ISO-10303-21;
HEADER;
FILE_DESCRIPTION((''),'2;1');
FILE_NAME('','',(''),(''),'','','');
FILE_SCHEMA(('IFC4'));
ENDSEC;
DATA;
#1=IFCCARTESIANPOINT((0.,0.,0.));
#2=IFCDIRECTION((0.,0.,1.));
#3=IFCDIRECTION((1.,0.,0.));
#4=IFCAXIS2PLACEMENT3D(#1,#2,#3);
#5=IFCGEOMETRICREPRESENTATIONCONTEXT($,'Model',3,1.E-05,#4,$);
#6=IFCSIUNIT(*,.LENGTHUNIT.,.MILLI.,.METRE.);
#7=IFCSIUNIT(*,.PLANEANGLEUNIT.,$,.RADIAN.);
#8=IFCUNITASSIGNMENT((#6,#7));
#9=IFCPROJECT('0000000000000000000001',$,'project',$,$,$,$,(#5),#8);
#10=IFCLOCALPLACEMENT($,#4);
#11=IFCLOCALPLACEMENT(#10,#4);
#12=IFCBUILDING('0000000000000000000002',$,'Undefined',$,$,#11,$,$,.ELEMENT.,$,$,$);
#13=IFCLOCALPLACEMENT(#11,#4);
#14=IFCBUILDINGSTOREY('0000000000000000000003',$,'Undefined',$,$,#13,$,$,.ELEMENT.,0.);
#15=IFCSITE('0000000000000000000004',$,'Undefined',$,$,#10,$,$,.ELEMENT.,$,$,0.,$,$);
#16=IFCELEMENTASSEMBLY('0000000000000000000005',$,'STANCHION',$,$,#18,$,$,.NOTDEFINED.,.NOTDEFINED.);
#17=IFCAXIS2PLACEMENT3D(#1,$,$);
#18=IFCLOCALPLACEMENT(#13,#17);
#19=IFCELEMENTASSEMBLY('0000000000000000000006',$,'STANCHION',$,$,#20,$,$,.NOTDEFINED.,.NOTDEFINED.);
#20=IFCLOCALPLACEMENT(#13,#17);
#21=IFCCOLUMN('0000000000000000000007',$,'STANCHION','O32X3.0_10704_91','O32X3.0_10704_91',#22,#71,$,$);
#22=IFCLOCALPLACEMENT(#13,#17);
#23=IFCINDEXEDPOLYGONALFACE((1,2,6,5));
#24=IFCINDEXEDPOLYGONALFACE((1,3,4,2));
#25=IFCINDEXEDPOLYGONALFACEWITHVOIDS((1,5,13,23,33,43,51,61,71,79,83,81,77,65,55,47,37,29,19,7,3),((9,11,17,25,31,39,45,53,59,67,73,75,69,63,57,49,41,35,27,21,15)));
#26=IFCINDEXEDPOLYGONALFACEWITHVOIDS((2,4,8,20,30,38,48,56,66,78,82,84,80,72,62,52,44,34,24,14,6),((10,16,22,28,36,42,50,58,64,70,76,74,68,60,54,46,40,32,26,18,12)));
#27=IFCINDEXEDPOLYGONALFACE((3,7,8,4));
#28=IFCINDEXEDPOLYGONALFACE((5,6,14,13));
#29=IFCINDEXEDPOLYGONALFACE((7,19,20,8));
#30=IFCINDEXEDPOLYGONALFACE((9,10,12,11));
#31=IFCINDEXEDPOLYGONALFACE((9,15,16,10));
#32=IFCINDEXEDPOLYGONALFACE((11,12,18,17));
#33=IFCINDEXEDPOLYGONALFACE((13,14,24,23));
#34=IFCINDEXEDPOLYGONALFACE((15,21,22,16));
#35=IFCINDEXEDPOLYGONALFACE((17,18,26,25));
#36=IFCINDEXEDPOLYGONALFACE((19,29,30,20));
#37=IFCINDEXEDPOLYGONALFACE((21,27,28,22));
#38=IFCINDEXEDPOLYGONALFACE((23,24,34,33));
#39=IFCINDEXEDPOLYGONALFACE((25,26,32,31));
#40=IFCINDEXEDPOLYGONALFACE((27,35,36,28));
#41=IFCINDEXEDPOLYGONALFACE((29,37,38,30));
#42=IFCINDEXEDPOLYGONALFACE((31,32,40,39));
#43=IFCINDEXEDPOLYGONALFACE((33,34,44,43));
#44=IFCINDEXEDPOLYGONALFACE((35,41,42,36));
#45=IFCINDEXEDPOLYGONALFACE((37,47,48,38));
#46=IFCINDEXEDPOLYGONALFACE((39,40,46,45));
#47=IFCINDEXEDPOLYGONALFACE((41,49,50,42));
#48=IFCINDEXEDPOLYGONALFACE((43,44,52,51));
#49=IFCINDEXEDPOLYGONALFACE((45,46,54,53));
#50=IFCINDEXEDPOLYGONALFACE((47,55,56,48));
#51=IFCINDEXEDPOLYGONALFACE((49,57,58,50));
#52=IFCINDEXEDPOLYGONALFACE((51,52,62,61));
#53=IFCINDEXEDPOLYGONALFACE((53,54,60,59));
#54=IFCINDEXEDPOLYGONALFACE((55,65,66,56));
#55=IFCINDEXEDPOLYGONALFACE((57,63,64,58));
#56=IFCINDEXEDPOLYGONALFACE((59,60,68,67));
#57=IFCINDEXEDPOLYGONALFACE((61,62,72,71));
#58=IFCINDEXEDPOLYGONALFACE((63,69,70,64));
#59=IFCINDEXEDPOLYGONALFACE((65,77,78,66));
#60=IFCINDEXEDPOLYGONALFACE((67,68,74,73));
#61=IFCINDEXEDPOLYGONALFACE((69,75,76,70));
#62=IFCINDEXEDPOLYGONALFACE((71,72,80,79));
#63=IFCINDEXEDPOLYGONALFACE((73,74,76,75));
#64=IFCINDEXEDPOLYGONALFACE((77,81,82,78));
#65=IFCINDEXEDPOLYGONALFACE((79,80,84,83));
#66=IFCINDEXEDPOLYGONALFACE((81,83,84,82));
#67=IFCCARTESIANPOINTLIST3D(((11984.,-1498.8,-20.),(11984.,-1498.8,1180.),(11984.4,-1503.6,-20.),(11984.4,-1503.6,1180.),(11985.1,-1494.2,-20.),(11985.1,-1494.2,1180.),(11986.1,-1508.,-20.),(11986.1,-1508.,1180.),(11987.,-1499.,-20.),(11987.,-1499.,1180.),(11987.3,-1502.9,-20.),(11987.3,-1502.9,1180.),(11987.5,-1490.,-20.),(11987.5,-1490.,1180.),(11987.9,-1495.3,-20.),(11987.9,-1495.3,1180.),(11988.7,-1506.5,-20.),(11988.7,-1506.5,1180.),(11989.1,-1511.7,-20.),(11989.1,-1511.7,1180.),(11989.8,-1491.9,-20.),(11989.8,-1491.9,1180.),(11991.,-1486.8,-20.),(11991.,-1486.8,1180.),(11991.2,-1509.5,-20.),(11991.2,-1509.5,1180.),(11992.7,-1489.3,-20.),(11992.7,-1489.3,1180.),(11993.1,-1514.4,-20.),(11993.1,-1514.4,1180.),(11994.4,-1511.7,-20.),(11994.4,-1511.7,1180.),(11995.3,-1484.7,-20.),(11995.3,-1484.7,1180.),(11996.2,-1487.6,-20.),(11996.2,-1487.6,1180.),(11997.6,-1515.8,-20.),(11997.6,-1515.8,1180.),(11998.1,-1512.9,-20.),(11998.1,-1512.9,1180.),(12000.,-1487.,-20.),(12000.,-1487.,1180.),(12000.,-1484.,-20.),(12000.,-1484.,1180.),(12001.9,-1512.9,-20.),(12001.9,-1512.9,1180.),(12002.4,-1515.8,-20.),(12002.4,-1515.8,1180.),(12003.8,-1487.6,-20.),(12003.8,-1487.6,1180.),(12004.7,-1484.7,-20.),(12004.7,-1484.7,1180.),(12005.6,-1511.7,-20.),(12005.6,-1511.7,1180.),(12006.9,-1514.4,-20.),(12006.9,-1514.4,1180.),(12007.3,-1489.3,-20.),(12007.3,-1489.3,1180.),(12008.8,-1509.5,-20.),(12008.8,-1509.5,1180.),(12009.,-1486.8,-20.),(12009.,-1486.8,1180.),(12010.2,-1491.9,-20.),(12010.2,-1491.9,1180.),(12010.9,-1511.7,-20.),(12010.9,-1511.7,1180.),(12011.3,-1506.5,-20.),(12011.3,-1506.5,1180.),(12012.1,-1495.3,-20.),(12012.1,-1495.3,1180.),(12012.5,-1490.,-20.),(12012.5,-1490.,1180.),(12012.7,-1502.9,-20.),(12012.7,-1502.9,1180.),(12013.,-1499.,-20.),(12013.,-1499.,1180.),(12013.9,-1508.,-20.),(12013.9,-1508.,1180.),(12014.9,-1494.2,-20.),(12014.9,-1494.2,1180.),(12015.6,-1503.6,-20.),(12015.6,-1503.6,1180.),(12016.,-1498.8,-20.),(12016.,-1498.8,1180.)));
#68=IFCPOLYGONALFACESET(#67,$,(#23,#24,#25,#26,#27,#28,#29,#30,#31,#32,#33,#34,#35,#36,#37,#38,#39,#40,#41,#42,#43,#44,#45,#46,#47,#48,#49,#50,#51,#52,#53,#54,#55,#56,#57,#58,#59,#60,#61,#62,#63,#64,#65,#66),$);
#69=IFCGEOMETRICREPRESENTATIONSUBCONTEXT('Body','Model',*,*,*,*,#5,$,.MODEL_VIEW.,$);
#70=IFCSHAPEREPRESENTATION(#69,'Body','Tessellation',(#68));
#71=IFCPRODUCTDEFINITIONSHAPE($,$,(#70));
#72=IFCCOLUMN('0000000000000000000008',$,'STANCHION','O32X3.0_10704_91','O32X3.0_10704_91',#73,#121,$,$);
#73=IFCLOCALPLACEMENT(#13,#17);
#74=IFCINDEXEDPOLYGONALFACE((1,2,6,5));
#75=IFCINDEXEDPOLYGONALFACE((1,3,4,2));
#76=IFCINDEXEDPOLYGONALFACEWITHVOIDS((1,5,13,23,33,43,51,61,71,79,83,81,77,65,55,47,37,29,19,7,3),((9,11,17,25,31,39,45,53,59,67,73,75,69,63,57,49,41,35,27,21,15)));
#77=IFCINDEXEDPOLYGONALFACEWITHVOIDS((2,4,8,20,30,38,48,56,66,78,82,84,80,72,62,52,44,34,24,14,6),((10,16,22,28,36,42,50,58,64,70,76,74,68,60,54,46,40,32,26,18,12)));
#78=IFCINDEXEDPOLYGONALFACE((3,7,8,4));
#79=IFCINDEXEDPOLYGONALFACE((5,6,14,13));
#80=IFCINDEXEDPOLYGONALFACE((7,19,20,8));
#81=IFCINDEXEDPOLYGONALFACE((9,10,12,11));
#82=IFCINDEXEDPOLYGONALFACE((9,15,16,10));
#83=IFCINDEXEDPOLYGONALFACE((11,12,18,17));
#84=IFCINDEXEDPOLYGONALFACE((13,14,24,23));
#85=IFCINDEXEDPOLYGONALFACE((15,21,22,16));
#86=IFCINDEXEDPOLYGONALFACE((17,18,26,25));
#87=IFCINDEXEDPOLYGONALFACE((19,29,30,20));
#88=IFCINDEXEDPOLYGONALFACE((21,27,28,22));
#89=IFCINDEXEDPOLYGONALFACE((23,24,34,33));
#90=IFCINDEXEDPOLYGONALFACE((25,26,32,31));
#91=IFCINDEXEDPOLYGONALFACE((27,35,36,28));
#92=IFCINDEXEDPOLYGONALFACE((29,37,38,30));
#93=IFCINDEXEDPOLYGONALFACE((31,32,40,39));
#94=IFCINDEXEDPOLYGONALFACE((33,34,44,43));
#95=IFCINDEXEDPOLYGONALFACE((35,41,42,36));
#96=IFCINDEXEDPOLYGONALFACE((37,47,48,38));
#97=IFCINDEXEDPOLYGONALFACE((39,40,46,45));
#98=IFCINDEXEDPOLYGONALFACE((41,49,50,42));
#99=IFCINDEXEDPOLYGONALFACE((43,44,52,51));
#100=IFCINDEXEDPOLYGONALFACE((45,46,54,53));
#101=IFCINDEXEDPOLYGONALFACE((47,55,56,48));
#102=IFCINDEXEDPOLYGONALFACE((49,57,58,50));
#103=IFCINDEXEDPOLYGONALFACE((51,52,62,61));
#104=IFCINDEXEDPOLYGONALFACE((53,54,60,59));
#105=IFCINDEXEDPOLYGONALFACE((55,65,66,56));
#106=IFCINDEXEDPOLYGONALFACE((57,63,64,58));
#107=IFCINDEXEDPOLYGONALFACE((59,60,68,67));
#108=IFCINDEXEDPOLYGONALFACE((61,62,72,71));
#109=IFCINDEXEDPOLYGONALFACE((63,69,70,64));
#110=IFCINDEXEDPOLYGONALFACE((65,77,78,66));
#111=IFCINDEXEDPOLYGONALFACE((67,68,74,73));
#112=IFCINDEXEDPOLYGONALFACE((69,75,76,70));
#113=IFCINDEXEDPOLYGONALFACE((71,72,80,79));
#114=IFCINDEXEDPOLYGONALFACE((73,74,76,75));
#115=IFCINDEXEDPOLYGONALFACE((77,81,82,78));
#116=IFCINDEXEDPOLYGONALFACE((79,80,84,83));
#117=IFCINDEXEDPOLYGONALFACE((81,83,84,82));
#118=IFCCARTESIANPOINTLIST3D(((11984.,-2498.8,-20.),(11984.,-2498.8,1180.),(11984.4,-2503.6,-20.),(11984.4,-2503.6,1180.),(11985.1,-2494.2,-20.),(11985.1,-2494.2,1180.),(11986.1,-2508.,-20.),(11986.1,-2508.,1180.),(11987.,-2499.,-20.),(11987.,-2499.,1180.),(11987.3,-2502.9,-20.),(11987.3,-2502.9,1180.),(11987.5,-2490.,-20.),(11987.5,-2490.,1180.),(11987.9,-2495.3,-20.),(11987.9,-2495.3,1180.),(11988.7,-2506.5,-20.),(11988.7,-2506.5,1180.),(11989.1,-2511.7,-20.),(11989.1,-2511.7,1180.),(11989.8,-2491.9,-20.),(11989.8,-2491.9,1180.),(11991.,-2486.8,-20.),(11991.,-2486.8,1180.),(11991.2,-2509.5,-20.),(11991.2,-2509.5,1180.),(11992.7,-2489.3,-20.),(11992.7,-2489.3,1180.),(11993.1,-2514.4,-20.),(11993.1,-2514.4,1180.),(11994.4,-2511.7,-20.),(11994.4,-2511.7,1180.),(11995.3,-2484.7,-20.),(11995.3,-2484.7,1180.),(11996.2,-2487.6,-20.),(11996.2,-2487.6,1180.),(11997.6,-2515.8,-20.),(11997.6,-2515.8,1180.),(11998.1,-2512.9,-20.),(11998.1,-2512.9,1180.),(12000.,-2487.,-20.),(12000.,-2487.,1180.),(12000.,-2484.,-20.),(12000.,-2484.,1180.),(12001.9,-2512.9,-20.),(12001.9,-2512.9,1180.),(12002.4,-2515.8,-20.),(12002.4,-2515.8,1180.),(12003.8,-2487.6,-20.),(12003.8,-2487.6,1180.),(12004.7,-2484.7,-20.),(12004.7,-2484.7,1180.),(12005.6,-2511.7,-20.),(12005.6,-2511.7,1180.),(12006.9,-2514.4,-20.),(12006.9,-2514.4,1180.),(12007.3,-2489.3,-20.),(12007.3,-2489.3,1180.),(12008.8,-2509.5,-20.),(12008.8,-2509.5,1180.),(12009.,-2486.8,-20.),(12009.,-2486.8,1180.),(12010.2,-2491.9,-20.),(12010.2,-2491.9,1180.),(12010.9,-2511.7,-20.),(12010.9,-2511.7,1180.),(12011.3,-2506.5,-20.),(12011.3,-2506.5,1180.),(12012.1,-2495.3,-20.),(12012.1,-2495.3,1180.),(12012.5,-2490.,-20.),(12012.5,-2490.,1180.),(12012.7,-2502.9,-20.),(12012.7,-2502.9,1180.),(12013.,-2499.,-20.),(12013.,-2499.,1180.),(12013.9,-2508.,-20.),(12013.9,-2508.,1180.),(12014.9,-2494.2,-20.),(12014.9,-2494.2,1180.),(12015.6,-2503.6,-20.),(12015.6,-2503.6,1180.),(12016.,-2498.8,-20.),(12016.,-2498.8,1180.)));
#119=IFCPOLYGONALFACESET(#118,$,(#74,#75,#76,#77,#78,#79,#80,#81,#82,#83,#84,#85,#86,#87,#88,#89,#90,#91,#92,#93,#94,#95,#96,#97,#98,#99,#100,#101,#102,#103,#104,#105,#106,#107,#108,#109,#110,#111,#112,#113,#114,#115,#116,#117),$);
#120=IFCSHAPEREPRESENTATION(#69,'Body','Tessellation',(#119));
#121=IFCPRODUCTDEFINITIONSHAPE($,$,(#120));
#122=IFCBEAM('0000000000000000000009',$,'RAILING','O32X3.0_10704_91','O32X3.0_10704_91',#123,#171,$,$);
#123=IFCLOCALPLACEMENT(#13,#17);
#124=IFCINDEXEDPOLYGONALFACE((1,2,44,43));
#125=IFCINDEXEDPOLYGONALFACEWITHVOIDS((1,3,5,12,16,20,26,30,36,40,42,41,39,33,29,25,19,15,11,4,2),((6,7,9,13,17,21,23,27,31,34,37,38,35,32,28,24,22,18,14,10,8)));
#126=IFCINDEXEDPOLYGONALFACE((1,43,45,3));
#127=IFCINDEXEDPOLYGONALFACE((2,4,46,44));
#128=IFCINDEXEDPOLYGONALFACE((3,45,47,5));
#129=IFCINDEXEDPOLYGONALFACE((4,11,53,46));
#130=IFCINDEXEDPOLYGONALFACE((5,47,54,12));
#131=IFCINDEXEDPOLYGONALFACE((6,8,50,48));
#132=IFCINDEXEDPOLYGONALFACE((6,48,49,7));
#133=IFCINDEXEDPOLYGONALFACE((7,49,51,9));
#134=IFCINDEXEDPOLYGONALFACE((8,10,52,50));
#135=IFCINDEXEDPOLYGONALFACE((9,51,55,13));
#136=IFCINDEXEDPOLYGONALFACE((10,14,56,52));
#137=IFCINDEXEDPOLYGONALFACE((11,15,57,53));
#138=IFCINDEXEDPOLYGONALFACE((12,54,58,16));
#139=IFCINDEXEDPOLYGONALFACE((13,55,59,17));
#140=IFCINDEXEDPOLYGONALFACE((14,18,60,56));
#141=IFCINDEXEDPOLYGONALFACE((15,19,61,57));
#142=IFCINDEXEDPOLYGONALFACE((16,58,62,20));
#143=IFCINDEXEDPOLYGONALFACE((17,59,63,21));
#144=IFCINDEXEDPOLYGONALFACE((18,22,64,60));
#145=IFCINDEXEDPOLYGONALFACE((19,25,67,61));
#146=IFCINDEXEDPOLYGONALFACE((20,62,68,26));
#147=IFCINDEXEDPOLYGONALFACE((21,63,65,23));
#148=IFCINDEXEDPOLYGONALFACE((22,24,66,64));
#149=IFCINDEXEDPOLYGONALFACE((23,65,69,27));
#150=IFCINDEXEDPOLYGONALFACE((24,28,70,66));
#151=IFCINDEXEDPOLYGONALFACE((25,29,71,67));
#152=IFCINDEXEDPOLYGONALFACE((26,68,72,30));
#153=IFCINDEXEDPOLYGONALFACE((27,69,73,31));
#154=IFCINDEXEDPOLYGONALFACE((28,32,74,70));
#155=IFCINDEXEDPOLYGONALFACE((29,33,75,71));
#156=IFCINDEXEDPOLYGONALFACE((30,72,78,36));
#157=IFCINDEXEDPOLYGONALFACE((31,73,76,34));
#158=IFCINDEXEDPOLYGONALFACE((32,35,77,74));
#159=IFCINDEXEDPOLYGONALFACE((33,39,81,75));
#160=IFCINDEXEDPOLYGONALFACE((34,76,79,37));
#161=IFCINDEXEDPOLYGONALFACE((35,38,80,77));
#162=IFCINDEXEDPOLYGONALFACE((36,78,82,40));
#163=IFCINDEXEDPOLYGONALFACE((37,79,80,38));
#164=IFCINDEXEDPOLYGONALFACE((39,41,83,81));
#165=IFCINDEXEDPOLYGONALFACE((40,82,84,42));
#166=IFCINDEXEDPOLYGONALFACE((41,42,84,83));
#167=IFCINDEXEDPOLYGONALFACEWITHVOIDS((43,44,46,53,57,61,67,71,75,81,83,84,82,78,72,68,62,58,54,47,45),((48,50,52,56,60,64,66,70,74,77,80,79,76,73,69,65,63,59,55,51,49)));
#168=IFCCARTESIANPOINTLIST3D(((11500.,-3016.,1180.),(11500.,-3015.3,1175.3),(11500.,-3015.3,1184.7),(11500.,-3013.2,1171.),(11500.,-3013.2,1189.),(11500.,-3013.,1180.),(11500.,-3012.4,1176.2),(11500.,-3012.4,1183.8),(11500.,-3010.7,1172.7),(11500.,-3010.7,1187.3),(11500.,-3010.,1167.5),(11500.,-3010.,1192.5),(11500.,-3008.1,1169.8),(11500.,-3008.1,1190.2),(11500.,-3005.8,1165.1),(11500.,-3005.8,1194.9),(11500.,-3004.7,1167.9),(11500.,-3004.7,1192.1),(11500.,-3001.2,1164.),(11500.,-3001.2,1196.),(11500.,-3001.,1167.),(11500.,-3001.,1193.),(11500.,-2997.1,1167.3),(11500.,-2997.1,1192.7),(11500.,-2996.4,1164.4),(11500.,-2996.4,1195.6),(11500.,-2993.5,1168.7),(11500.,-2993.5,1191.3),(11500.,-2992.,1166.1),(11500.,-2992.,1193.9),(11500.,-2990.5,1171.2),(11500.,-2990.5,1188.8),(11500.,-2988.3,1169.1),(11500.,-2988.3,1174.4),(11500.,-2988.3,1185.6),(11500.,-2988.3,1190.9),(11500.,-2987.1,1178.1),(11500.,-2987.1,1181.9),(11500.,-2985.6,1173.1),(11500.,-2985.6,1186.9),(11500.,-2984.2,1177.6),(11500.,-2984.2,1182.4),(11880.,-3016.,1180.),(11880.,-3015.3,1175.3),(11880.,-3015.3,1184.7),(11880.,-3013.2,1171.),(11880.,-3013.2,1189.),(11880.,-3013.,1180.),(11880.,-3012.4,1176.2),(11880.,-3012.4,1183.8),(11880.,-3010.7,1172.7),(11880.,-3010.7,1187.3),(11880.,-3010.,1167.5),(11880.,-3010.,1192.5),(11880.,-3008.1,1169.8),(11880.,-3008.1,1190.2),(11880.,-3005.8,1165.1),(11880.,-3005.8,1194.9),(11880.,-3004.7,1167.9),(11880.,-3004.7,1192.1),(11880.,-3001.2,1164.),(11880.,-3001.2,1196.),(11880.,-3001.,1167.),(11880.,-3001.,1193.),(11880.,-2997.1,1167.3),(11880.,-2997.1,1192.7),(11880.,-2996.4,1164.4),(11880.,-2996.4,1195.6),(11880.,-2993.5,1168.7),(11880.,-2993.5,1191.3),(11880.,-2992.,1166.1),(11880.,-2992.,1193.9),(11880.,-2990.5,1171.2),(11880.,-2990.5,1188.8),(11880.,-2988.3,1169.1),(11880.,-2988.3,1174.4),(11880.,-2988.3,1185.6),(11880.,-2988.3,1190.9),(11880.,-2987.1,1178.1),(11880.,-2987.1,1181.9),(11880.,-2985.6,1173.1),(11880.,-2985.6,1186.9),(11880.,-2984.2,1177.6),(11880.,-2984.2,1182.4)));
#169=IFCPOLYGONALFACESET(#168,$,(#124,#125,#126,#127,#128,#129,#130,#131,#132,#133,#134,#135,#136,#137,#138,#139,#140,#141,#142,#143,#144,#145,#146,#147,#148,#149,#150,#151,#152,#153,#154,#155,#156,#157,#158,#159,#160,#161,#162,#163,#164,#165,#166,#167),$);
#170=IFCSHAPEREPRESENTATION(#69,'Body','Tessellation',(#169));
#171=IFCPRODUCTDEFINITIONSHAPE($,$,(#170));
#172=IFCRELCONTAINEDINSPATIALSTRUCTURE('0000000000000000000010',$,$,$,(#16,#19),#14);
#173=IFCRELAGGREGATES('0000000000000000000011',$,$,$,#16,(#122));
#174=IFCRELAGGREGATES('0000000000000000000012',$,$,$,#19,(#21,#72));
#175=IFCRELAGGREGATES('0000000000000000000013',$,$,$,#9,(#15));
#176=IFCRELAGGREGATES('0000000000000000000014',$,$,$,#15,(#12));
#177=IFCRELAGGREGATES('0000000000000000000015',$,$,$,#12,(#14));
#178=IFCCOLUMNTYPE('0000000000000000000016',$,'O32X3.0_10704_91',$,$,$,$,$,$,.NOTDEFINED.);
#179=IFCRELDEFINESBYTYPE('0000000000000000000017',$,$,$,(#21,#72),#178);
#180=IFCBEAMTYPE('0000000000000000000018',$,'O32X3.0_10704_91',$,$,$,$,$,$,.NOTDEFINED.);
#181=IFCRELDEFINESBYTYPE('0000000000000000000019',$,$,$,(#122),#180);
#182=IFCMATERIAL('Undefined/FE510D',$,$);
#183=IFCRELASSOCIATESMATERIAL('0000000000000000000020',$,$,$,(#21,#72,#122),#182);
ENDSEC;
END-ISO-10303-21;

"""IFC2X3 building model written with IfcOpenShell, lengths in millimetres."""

from ifc_helpers import new_model, si_unit, frame, origin_with_axes, origin_2d_with_axis, place, context, subcontext, project, spatial, hollow_circle, extrude, material, type_object, element, aggregate, save


model = new_model("IFC2X3")

# Units and contexts
model_context = context("Model", 3, precision=1e-05, world=origin_with_axes())
body_context = subcontext(model_context, "Body", "Model", "MODEL_VIEW")
ifc_project = project(units=[si_unit("LENGTHUNIT", "METRE", prefix="MILLI"), si_unit("PLANEANGLEUNIT", "RADIAN")], contexts=[model_context])

# Site, building, storey
site_placement = place(None, origin_with_axes())
site = spatial("IfcSite", under=ifc_project, at=site_placement, Name="Undefined", CompositionType="ELEMENT", RefElevation=0.0)
building_placement = place(site_placement, origin_with_axes())
building = spatial("IfcBuilding", under=site, at=building_placement, Name="Undefined", CompositionType="ELEMENT")
storey_placement = place(building_placement, origin_with_axes())
storey = spatial("IfcBuildingStorey", under=building, at=storey_placement, Name="Undefined", CompositionType="ELEMENT", Elevation=0.0)

# Element assemblies
assembly_1_placement = place(storey_placement, origin_with_axes())
assembly_1 = element("IfcElementAssembly", 1, at=assembly_1_placement, inside=storey, Name="STANCHION", AssemblyPlace="NOTDEFINED", PredefinedType="NOTDEFINED")
column_type = type_object("IfcColumnType", Name="O32X3.0_10704_91", PredefinedType="NOTDEFINED")
assembly_2_placement = place(storey_placement, origin_with_axes())
assembly_2 = element("IfcElementAssembly", 2, at=assembly_2_placement, inside=storey, Name="STANCHION", AssemblyPlace="NOTDEFINED", PredefinedType="NOTDEFINED")
ifc_material_1 = material(Name="Undefined/FE510D")

# Columns
column_1_placement = place(assembly_2_placement, frame((12000.0, -1500.0, -20.0), z_axis=(0.0, 0.0, 1.0), x_axis=(1.0, 0.0, 0.0)))
column_1 = element("IfcColumn", 3, at=column_1_placement, type_object=column_type, material=ifc_material_1, Name="STANCHION", Description="O32X3.0_10704_91", ObjectType="O32X3.0_10704_91", context=body_context, shape_type="SweptSolid", body=[
    extrude(hollow_circle(Radius=16.0, WallThickness=3.0, at=origin_2d_with_axis()), frame((0.0, 0.0, 1200.0), z_axis=(0.0, 0.0, -1.0), x_axis=(0.0, 1.0, 0.0)), (0.0, 0.0, 1.0), 1200.0),
])
column_2_placement = place(assembly_2_placement, frame((12000.0, -2500.0, -20.0), z_axis=(0.0, 0.0, 1.0), x_axis=(1.0, 0.0, 0.0)))
column_2 = element("IfcColumn", 4, at=column_2_placement, type_object=column_type, material=ifc_material_1, Name="STANCHION", Description="O32X3.0_10704_91", ObjectType="O32X3.0_10704_91", context=body_context, shape_type="SweptSolid", body=[
    extrude(hollow_circle(Radius=16.0, WallThickness=3.0, at=origin_2d_with_axis()), frame((0.0, 0.0, 1200.0), z_axis=(0.0, 0.0, -1.0), x_axis=(0.0, 1.0, 0.0)), (0.0, 0.0, 1.0), 1200.0),
])

# Beam
beam_type_1 = type_object("IfcBeamType", Name="O32X3.0_10704_91", PredefinedType="NOTDEFINED")
beam_1_placement = place(assembly_1_placement, frame((11500.0, -3000.0, 1180.0), z_axis=(0.0, 0.0, 1.0), x_axis=(1.0, 0.0, 0.0)))
beam_1 = element("IfcBeam", 5, at=beam_1_placement, type_object=beam_type_1, material=ifc_material_1, Name="RAILING", Description="O32X3.0_10704_91", ObjectType="O32X3.0_10704_91", context=body_context, shape_type="SweptSolid", body=[
    extrude(hollow_circle(Radius=16.0, WallThickness=3.0, at=origin_2d_with_axis()), frame((380.0, 0.0, 0.0), z_axis=(-1.0, 0.0, 0.0), x_axis=(0.0, -1.0, 0.0)), (0.0, 0.0, 1.0), 380.0),
])
aggregate(assembly_1, [beam_1])
aggregate(assembly_2, [column_1, column_2])

save(model, "model.ifc")
